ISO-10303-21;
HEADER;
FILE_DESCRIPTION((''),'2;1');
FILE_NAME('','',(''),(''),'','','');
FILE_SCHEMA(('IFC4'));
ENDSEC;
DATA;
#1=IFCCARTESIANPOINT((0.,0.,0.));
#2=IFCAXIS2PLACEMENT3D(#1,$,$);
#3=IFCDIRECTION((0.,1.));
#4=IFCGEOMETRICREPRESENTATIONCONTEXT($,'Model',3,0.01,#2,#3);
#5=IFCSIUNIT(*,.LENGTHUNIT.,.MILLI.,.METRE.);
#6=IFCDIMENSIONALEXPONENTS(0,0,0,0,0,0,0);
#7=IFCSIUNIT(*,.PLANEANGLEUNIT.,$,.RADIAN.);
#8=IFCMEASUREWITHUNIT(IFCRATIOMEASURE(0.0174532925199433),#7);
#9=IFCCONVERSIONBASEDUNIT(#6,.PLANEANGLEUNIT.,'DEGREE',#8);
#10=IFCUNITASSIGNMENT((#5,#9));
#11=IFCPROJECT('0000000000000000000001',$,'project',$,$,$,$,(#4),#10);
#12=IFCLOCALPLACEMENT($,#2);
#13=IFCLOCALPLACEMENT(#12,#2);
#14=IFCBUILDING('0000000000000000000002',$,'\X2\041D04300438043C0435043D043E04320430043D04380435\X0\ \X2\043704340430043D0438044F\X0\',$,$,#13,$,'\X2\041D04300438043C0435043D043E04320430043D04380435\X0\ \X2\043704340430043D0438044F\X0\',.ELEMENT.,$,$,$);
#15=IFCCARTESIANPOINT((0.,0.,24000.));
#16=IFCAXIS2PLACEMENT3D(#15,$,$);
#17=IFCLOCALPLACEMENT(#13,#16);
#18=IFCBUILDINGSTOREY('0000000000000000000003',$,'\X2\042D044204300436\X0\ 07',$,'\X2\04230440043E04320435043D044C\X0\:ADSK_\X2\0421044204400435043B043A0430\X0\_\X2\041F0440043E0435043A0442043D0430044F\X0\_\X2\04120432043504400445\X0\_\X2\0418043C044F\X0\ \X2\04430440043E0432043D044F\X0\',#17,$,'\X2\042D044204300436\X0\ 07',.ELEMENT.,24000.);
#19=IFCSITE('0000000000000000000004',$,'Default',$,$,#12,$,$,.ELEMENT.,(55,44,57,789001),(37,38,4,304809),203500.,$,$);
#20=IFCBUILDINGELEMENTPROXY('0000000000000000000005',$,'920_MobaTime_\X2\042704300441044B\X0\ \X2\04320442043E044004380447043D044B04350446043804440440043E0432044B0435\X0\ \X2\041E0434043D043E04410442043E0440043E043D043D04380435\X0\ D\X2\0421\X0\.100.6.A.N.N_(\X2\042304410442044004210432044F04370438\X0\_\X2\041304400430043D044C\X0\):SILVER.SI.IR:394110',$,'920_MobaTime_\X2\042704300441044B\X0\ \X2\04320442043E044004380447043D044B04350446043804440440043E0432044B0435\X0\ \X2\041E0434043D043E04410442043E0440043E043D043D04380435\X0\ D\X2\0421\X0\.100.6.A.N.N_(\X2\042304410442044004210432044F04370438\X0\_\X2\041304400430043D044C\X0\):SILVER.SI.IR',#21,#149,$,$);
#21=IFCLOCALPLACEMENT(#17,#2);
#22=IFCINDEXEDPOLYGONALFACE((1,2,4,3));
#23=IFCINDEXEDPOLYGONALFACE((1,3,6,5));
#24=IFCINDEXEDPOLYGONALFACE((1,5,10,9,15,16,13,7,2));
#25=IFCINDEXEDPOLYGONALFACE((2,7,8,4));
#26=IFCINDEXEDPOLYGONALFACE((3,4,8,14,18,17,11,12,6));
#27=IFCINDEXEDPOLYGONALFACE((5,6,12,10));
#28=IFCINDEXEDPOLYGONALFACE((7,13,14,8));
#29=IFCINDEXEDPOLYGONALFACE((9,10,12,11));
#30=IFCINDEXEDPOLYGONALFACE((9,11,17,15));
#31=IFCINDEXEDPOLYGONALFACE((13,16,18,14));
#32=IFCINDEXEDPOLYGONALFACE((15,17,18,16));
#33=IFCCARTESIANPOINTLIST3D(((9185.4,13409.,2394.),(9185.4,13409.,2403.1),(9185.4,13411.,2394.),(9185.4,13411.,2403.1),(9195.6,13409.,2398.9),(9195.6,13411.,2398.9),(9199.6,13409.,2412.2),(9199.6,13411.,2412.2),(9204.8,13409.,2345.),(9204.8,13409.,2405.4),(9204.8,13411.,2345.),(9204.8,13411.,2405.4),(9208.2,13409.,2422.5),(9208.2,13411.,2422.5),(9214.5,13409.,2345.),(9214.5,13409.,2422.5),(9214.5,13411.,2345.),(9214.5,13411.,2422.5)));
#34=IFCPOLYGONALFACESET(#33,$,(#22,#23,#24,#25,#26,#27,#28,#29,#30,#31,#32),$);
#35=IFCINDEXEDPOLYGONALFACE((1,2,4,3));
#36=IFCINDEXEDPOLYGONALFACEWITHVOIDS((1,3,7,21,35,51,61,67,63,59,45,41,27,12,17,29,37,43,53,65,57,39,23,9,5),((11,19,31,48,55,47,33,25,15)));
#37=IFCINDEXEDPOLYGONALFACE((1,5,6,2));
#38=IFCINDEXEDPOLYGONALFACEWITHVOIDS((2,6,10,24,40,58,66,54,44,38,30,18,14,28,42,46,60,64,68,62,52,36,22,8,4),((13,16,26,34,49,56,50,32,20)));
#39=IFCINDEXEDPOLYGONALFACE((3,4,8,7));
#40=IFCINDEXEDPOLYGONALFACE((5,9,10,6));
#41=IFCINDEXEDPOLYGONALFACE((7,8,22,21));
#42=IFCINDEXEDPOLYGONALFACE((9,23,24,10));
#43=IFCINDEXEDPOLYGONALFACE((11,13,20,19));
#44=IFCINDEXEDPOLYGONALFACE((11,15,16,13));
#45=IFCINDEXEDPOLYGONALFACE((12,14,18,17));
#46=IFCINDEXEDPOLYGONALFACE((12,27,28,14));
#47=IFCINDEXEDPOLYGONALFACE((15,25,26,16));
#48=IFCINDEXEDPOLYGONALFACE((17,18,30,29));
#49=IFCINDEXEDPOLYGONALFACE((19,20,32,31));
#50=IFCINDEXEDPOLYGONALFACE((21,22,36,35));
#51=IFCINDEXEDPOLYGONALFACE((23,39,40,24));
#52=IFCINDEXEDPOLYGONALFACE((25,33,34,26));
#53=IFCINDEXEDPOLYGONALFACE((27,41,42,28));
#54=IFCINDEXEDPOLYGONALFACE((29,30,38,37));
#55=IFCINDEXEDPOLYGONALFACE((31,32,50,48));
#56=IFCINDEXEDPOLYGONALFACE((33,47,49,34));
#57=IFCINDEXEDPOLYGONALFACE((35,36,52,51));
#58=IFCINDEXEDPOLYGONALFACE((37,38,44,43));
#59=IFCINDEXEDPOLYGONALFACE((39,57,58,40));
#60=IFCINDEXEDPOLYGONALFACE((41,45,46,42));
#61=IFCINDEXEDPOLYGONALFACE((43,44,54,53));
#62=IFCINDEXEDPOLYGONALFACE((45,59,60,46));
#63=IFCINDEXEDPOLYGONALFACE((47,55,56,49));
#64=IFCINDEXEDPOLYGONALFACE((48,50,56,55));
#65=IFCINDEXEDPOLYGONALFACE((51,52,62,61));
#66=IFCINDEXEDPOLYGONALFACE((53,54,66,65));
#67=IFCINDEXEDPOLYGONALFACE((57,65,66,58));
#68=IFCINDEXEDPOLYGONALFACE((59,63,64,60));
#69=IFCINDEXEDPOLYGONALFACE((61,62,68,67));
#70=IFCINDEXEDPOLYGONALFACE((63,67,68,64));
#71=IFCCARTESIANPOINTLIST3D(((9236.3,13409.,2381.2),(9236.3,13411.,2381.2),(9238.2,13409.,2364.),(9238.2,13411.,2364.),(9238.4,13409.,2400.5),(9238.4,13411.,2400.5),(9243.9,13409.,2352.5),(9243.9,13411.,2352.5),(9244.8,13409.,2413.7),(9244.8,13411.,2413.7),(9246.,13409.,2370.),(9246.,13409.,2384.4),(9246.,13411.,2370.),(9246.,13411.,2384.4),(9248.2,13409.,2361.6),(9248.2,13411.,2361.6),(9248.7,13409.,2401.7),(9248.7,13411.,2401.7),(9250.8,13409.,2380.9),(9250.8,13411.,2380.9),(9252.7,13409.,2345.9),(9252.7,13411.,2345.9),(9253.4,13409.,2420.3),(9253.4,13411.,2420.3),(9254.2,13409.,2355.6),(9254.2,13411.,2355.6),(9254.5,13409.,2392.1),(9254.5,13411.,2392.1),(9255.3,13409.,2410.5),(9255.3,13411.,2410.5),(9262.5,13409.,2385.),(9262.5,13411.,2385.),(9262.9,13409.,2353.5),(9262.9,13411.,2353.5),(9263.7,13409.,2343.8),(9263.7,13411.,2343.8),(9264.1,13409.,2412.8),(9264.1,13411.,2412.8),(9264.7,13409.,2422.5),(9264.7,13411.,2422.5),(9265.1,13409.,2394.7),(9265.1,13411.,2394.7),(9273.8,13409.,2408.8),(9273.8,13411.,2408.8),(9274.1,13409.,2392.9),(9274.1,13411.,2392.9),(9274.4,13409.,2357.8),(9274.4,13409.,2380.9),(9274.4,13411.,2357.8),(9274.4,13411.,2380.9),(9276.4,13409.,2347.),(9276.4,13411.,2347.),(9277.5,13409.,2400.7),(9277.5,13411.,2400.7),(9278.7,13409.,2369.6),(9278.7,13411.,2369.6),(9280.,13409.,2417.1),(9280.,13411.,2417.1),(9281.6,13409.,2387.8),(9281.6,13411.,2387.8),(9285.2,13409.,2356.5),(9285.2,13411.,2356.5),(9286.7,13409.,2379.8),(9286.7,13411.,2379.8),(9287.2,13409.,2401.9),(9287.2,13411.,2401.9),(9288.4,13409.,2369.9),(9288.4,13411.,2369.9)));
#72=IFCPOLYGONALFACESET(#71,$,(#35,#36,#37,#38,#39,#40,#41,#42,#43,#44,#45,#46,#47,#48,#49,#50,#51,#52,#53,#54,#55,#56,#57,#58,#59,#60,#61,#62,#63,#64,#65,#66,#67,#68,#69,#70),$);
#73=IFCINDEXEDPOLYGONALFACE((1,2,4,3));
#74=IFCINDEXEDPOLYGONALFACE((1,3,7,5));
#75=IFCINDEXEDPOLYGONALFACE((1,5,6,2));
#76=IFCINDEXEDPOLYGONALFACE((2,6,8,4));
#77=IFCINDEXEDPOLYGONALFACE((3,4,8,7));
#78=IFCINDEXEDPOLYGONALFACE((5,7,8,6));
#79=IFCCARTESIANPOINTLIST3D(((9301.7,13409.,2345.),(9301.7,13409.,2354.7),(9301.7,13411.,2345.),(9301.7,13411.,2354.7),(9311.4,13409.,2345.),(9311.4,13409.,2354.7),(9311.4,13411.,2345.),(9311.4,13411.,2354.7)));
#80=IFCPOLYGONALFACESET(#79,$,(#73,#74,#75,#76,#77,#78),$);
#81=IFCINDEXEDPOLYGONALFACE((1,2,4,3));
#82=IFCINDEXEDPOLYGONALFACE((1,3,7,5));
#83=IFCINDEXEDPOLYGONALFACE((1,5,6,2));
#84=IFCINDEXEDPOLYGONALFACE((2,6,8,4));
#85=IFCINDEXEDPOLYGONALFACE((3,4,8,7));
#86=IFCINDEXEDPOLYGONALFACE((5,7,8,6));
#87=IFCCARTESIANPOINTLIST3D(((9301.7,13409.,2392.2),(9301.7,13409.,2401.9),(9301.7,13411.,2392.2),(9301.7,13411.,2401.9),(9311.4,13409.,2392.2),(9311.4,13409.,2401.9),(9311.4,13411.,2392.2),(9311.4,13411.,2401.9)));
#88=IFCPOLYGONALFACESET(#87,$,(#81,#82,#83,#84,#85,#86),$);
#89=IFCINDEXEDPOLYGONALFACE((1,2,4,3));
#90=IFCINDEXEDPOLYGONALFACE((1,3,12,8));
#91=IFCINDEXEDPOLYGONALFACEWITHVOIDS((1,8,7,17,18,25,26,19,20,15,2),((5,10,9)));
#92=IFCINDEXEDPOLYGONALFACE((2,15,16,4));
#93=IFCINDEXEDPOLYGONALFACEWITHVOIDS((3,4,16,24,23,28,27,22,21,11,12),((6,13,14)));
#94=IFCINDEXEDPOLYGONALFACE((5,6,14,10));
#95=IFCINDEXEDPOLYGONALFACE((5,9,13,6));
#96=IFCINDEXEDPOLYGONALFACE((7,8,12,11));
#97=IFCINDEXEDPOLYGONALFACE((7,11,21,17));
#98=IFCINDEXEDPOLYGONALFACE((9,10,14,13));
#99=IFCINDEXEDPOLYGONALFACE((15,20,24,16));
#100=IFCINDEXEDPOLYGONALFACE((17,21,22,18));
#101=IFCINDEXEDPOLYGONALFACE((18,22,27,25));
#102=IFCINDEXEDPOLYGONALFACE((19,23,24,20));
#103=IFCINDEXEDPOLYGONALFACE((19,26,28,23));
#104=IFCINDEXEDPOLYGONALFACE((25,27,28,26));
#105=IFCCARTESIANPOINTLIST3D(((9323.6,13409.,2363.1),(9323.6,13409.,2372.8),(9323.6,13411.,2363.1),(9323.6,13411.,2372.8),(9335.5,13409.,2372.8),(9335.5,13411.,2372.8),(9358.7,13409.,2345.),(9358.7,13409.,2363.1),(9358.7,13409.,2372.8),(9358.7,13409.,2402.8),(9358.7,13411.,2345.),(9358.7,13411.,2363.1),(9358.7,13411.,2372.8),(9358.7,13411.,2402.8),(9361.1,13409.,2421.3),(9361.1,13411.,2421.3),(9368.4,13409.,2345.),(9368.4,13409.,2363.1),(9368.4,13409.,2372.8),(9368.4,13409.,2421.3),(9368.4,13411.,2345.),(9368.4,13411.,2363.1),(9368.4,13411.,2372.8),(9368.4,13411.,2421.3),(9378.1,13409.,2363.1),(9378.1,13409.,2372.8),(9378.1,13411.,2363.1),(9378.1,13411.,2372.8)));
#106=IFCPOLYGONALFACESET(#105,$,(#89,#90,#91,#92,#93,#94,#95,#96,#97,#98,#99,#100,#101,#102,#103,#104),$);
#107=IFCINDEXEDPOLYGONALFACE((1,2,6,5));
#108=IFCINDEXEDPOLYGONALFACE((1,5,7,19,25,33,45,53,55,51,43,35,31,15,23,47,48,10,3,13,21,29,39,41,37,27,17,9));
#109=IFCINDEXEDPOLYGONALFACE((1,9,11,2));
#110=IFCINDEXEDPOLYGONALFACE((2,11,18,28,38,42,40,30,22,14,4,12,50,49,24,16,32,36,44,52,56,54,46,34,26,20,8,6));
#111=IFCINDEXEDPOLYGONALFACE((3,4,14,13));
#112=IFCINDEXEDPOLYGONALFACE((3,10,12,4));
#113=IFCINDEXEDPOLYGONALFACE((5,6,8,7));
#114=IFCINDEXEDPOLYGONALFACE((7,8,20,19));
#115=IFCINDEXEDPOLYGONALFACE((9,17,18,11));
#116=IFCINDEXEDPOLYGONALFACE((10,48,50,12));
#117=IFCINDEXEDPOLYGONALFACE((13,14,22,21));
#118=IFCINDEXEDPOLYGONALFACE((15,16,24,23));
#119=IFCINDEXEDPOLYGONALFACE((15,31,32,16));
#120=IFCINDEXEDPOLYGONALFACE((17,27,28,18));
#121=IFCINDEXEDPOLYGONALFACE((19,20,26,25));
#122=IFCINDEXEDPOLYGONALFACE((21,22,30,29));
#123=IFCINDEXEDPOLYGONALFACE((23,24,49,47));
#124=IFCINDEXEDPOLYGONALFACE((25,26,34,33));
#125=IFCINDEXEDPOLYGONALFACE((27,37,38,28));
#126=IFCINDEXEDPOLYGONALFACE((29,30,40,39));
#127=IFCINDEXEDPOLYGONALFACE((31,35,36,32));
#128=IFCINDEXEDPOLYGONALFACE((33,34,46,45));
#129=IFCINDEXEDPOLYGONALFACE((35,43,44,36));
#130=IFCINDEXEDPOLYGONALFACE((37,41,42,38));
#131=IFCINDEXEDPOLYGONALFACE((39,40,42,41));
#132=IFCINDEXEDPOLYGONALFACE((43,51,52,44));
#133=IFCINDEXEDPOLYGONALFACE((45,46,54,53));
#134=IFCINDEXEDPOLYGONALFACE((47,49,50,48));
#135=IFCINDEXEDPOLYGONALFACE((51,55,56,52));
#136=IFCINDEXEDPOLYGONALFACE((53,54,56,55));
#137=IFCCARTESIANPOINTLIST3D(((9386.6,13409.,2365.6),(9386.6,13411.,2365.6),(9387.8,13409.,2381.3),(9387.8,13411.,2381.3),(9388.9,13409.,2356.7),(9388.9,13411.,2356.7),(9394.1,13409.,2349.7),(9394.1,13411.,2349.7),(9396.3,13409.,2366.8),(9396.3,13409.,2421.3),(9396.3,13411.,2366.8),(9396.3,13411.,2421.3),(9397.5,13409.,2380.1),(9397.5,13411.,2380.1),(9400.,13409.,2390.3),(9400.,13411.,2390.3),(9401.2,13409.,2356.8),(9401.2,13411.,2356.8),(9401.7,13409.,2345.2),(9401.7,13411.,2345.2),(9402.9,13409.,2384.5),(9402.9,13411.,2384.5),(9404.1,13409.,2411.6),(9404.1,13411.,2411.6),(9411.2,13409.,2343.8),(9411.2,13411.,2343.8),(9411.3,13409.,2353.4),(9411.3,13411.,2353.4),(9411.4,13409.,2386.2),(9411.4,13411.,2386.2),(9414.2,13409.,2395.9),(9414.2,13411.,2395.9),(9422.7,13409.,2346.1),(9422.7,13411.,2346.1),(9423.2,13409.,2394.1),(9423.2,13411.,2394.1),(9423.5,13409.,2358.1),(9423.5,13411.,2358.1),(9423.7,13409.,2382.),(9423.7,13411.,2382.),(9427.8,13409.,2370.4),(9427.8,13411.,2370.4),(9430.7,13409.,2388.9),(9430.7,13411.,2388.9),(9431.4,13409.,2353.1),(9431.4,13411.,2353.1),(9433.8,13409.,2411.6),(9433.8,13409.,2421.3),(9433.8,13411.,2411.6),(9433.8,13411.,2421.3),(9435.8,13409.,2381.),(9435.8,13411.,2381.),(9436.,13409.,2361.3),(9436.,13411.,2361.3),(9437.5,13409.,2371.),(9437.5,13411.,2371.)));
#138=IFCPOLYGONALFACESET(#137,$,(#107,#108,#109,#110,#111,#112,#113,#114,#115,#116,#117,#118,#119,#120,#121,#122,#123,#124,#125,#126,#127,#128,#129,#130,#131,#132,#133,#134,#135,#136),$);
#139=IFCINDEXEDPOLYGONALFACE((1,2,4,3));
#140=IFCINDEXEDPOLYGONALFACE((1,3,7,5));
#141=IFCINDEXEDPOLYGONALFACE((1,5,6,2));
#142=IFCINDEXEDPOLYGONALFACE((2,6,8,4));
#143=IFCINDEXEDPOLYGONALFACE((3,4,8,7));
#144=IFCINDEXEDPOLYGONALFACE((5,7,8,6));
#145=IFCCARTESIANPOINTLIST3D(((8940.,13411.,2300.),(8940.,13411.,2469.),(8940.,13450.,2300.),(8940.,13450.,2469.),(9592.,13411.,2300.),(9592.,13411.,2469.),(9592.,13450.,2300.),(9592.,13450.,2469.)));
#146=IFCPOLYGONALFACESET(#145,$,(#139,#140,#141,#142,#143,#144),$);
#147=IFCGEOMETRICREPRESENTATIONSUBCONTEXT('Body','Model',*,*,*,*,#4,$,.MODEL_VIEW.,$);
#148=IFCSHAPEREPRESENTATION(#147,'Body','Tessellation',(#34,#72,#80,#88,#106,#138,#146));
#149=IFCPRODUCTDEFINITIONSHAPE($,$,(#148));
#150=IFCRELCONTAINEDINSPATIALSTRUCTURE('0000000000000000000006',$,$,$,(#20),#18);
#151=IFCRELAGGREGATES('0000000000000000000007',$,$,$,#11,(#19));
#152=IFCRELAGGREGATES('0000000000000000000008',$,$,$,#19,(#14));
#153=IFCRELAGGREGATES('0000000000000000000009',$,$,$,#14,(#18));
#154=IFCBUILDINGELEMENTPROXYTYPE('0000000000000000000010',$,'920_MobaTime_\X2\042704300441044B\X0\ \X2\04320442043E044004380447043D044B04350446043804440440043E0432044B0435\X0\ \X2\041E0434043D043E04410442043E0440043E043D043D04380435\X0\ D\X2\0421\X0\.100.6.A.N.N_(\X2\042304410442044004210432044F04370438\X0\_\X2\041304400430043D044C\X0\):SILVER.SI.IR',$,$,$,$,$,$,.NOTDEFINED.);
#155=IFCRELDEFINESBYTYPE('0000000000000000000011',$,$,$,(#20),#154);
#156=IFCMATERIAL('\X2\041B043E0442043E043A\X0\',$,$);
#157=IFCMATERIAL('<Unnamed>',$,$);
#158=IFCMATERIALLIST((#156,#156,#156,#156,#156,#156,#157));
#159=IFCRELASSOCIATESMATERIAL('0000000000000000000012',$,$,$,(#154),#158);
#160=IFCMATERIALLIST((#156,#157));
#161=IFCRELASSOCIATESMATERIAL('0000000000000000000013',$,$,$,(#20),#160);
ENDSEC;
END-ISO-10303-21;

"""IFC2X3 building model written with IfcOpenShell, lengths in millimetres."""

from ifc_helpers import new_model, entity, si_unit, converted_unit, direction, frame, origin, origin_2d_with_axis, place, context, subcontext, project, spatial, polyline, rectangle, outline, extrude, source, transform, mapped, material, material_list, type_object, type_shapes, element, save


model = new_model("IFC2X3")

# Units and contexts
model_context = context("Model", 3, precision=0.01, world=origin(), true_north=direction((0.0, 1.0)))
body_context = subcontext(model_context, "Body", "Model", "MODEL_VIEW")
ifc_project = project(units=[si_unit("LENGTHUNIT", "METRE", prefix="MILLI"), converted_unit("PLANEANGLEUNIT", "DEGREE", entity("IfcRatioMeasure", 0.0174532925199433), si_unit("PLANEANGLEUNIT", "RADIAN"), dimensions=[0, 0, 0, 0, 0, 0, 0])], contexts=[model_context])

# Site, building, storey
site_placement = place(None, origin())
site = spatial("IfcSite", under=ifc_project, at=site_placement, Name="Default", CompositionType="ELEMENT", RefLatitude=(55, 44, 57, 789001), RefLongitude=(37, 38, 4, 304809), RefElevation=203500.0)
building_placement = place(site_placement, origin())
building = spatial("IfcBuilding", under=site, at=building_placement, Name="Наименование здания", LongName="Наименование здания", CompositionType="ELEMENT")
storey_placement = place(building_placement, frame((0.0, 0.0, 24000.0)))
storey = spatial("IfcBuildingStorey", under=building, at=storey_placement, Name="Этаж 07", ObjectType="Уровень:ADSK_Стрелка_Проектная_Вверх_Имя уровня", LongName="Этаж 07", CompositionType="ELEMENT", Elevation=24000.0)

# Building element proxy
ifc_material_1 = material(Name="Лоток")
ifc_material_2 = material(Name="<Unnamed>")
ifc_material_list_1 = material_list([ifc_material_1, ifc_material_2])
ifc_material_list_2 = material_list([ifc_material_1, ifc_material_1, ifc_material_1, ifc_material_1, ifc_material_1, ifc_material_1, ifc_material_2])
building_element_proxy_type = type_object("IfcBuildingElementProxyType", Name="920_MobaTime_Часы вторичныецифровые Односторонние DС.100.6.A.N.N_(УстрСвязи_Грань):SILVER.SI.IR", PredefinedType="NOTDEFINED", material=ifc_material_list_2)
shared_shape = source(origin(), body_context, "Body", "SweptSolid", [
    extrude(outline(polyline([(-49.3, -13.1), (28.2, -13.1), (28.2, -6.8), (17.9, 1.8), (8.8, 16.0), (-0.3, 16.0), (4.6, 5.8), (11.1, -3.4), (-49.3, -3.4), (-49.3, -13.1)])), frame((-64.6, 9.8, 39.0), z_axis=(0.0, 0.0, 1.0), x_axis=(0.0, 1.0, 0.0)), (0.0, 0.0, 1.0), 2.0),
    extrude(outline(polyline([(2.2, -27.6), (19.0, -27.6), (30.5, -16.1), (33.3, -4.9), (31.0, 5.8), (21.8, 17.2), (5.2, 27.3), (-11.1, 33.0), (-24.0, 32.7), (-33.6, 27.6), (-40.3, 18.6), (-42.8, 5.7), (-38.0, -6.3), (-27.2, -14.9), (-17.5, -17.7), (-8.2, -16.4), (-0.3, -11.9), (5.1, -4.5), (7.3, 6.2), (4.0, 17.2), (18.4, 7.3), (23.6, -2.4), (22.0, -11.4), (14.2, -18.4), (5.3, -18.3), (2.2, -27.6)]), holes=[polyline([(-9.0, 23.3), (-1.3, 14.3), (-2.5, 2.0), (-11.4, -7.0), (-23.4, -6.0), (-32.2, 2.9), (-31.2, 15.1), (-25.6, 22.1), (-17.5, 24.9), (-9.0, 23.3)])]), frame((-2.7, 3.6, 39.0), z_axis=(0.0, 0.0, 1.0), x_axis=(-0.427649, 0.903945, 0.0)), (0.0, 0.0, 1.0), 2.0),
    extrude(rectangle(XDim=9.7, YDim=9.7, at=origin_2d_with_axis()), frame((40.6, -34.7, 39.0)), (0.0, 0.0, 1.0), 2.0),
    extrude(rectangle(XDim=9.7, YDim=9.7, at=origin_2d_with_axis()), frame((40.6, 12.6, 39.0)), (0.0, 0.0, 1.0), 2.0),
    extrude(outline(polyline([(-0.9, -28.1), (8.8, -28.1), (8.8, -9.9), (18.5, -9.9), (18.5, -0.2), (8.8, -0.2), (8.8, 48.3), (1.5, 48.3), (-36.0, -0.2), (-36.0, -9.9), (-0.9, -9.9), (-0.9, -28.1)]), holes=[polyline([(-0.9, -0.2), (-24.1, -0.2), (-0.9, 29.7), (-0.9, -0.2)])]), frame((93.6, -11.4, 39.0)), (0.0, 0.0, 1.0), 2.0),
    extrude(outline(polyline([(3.3, -28.3), (12.5, -28.3), (20.5, -25.0), (26.8, -18.9), (30.7, -10.0), (31.4, 1.6), (26.9, 11.8), (20.1, 18.4), (11.1, 22.3), (1.0, 23.3), (-7.9, 20.4), (-14.9, 14.5), (-18.9, 6.2), (-17.1, -9.0), (-36.7, 0.5), (-29.1, 29.2), (-38.5, 31.7), (-48.1, -4.6), (-11.6, -23.1), (-8.0, -14.0), (-10.8, -7.6), (-10.2, 1.1), (-3.0, 11.8), (9.2, 12.8), (20.0, 5.5), (21.4, -7.5), (15.5, -16.4), (4.6, -18.6), (3.3, -28.3)])), frame((147.1, -8.5, 39.0), z_axis=(0.0, 0.0, 1.0), x_axis=(0.256974, -0.966418, 0.0)), (0.0, 0.0, 1.0), 2.0),
    extrude(rectangle(XDim=652.0, YDim=169.0, at=origin_2d_with_axis()), frame((0.0, 0.0, 0.0), z_axis=(0.0, 0.0, 1.0), x_axis=(-1.0, 0.0, 0.0)), (0.0, 0.0, 1.0), 39.0),
])
type_shapes(building_element_proxy_type, [shared_shape])
for number, where, z_axis, x_axis, name in (
    (1, (9266.0, 13450.0, 2384.5), (0.0, -1.0, 0.0), (1.0, 0.0, 0.0), "920_MobaTime_Часы вторичныецифровые Односторонние DС.100.6.A.N.N_(УстрСвязи_Грань):SILVER.SI.IR:394110"),
):
    element("IfcBuildingElementProxy", number, at=place(storey_placement, frame(where, z_axis=z_axis, x_axis=x_axis)), inside=storey, type_object=building_element_proxy_type, material=ifc_material_list_1, Name=name, ObjectType="920_MobaTime_Часы вторичныецифровые Односторонние DС.100.6.A.N.N_(УстрСвязи_Грань):SILVER.SI.IR", context=body_context, shape_type="MappedRepresentation", body=[
        mapped(shared_shape, transform((0.0, 0.0, 0.0), scale=1.0)),
    ])

save(model, "model.ifc")
